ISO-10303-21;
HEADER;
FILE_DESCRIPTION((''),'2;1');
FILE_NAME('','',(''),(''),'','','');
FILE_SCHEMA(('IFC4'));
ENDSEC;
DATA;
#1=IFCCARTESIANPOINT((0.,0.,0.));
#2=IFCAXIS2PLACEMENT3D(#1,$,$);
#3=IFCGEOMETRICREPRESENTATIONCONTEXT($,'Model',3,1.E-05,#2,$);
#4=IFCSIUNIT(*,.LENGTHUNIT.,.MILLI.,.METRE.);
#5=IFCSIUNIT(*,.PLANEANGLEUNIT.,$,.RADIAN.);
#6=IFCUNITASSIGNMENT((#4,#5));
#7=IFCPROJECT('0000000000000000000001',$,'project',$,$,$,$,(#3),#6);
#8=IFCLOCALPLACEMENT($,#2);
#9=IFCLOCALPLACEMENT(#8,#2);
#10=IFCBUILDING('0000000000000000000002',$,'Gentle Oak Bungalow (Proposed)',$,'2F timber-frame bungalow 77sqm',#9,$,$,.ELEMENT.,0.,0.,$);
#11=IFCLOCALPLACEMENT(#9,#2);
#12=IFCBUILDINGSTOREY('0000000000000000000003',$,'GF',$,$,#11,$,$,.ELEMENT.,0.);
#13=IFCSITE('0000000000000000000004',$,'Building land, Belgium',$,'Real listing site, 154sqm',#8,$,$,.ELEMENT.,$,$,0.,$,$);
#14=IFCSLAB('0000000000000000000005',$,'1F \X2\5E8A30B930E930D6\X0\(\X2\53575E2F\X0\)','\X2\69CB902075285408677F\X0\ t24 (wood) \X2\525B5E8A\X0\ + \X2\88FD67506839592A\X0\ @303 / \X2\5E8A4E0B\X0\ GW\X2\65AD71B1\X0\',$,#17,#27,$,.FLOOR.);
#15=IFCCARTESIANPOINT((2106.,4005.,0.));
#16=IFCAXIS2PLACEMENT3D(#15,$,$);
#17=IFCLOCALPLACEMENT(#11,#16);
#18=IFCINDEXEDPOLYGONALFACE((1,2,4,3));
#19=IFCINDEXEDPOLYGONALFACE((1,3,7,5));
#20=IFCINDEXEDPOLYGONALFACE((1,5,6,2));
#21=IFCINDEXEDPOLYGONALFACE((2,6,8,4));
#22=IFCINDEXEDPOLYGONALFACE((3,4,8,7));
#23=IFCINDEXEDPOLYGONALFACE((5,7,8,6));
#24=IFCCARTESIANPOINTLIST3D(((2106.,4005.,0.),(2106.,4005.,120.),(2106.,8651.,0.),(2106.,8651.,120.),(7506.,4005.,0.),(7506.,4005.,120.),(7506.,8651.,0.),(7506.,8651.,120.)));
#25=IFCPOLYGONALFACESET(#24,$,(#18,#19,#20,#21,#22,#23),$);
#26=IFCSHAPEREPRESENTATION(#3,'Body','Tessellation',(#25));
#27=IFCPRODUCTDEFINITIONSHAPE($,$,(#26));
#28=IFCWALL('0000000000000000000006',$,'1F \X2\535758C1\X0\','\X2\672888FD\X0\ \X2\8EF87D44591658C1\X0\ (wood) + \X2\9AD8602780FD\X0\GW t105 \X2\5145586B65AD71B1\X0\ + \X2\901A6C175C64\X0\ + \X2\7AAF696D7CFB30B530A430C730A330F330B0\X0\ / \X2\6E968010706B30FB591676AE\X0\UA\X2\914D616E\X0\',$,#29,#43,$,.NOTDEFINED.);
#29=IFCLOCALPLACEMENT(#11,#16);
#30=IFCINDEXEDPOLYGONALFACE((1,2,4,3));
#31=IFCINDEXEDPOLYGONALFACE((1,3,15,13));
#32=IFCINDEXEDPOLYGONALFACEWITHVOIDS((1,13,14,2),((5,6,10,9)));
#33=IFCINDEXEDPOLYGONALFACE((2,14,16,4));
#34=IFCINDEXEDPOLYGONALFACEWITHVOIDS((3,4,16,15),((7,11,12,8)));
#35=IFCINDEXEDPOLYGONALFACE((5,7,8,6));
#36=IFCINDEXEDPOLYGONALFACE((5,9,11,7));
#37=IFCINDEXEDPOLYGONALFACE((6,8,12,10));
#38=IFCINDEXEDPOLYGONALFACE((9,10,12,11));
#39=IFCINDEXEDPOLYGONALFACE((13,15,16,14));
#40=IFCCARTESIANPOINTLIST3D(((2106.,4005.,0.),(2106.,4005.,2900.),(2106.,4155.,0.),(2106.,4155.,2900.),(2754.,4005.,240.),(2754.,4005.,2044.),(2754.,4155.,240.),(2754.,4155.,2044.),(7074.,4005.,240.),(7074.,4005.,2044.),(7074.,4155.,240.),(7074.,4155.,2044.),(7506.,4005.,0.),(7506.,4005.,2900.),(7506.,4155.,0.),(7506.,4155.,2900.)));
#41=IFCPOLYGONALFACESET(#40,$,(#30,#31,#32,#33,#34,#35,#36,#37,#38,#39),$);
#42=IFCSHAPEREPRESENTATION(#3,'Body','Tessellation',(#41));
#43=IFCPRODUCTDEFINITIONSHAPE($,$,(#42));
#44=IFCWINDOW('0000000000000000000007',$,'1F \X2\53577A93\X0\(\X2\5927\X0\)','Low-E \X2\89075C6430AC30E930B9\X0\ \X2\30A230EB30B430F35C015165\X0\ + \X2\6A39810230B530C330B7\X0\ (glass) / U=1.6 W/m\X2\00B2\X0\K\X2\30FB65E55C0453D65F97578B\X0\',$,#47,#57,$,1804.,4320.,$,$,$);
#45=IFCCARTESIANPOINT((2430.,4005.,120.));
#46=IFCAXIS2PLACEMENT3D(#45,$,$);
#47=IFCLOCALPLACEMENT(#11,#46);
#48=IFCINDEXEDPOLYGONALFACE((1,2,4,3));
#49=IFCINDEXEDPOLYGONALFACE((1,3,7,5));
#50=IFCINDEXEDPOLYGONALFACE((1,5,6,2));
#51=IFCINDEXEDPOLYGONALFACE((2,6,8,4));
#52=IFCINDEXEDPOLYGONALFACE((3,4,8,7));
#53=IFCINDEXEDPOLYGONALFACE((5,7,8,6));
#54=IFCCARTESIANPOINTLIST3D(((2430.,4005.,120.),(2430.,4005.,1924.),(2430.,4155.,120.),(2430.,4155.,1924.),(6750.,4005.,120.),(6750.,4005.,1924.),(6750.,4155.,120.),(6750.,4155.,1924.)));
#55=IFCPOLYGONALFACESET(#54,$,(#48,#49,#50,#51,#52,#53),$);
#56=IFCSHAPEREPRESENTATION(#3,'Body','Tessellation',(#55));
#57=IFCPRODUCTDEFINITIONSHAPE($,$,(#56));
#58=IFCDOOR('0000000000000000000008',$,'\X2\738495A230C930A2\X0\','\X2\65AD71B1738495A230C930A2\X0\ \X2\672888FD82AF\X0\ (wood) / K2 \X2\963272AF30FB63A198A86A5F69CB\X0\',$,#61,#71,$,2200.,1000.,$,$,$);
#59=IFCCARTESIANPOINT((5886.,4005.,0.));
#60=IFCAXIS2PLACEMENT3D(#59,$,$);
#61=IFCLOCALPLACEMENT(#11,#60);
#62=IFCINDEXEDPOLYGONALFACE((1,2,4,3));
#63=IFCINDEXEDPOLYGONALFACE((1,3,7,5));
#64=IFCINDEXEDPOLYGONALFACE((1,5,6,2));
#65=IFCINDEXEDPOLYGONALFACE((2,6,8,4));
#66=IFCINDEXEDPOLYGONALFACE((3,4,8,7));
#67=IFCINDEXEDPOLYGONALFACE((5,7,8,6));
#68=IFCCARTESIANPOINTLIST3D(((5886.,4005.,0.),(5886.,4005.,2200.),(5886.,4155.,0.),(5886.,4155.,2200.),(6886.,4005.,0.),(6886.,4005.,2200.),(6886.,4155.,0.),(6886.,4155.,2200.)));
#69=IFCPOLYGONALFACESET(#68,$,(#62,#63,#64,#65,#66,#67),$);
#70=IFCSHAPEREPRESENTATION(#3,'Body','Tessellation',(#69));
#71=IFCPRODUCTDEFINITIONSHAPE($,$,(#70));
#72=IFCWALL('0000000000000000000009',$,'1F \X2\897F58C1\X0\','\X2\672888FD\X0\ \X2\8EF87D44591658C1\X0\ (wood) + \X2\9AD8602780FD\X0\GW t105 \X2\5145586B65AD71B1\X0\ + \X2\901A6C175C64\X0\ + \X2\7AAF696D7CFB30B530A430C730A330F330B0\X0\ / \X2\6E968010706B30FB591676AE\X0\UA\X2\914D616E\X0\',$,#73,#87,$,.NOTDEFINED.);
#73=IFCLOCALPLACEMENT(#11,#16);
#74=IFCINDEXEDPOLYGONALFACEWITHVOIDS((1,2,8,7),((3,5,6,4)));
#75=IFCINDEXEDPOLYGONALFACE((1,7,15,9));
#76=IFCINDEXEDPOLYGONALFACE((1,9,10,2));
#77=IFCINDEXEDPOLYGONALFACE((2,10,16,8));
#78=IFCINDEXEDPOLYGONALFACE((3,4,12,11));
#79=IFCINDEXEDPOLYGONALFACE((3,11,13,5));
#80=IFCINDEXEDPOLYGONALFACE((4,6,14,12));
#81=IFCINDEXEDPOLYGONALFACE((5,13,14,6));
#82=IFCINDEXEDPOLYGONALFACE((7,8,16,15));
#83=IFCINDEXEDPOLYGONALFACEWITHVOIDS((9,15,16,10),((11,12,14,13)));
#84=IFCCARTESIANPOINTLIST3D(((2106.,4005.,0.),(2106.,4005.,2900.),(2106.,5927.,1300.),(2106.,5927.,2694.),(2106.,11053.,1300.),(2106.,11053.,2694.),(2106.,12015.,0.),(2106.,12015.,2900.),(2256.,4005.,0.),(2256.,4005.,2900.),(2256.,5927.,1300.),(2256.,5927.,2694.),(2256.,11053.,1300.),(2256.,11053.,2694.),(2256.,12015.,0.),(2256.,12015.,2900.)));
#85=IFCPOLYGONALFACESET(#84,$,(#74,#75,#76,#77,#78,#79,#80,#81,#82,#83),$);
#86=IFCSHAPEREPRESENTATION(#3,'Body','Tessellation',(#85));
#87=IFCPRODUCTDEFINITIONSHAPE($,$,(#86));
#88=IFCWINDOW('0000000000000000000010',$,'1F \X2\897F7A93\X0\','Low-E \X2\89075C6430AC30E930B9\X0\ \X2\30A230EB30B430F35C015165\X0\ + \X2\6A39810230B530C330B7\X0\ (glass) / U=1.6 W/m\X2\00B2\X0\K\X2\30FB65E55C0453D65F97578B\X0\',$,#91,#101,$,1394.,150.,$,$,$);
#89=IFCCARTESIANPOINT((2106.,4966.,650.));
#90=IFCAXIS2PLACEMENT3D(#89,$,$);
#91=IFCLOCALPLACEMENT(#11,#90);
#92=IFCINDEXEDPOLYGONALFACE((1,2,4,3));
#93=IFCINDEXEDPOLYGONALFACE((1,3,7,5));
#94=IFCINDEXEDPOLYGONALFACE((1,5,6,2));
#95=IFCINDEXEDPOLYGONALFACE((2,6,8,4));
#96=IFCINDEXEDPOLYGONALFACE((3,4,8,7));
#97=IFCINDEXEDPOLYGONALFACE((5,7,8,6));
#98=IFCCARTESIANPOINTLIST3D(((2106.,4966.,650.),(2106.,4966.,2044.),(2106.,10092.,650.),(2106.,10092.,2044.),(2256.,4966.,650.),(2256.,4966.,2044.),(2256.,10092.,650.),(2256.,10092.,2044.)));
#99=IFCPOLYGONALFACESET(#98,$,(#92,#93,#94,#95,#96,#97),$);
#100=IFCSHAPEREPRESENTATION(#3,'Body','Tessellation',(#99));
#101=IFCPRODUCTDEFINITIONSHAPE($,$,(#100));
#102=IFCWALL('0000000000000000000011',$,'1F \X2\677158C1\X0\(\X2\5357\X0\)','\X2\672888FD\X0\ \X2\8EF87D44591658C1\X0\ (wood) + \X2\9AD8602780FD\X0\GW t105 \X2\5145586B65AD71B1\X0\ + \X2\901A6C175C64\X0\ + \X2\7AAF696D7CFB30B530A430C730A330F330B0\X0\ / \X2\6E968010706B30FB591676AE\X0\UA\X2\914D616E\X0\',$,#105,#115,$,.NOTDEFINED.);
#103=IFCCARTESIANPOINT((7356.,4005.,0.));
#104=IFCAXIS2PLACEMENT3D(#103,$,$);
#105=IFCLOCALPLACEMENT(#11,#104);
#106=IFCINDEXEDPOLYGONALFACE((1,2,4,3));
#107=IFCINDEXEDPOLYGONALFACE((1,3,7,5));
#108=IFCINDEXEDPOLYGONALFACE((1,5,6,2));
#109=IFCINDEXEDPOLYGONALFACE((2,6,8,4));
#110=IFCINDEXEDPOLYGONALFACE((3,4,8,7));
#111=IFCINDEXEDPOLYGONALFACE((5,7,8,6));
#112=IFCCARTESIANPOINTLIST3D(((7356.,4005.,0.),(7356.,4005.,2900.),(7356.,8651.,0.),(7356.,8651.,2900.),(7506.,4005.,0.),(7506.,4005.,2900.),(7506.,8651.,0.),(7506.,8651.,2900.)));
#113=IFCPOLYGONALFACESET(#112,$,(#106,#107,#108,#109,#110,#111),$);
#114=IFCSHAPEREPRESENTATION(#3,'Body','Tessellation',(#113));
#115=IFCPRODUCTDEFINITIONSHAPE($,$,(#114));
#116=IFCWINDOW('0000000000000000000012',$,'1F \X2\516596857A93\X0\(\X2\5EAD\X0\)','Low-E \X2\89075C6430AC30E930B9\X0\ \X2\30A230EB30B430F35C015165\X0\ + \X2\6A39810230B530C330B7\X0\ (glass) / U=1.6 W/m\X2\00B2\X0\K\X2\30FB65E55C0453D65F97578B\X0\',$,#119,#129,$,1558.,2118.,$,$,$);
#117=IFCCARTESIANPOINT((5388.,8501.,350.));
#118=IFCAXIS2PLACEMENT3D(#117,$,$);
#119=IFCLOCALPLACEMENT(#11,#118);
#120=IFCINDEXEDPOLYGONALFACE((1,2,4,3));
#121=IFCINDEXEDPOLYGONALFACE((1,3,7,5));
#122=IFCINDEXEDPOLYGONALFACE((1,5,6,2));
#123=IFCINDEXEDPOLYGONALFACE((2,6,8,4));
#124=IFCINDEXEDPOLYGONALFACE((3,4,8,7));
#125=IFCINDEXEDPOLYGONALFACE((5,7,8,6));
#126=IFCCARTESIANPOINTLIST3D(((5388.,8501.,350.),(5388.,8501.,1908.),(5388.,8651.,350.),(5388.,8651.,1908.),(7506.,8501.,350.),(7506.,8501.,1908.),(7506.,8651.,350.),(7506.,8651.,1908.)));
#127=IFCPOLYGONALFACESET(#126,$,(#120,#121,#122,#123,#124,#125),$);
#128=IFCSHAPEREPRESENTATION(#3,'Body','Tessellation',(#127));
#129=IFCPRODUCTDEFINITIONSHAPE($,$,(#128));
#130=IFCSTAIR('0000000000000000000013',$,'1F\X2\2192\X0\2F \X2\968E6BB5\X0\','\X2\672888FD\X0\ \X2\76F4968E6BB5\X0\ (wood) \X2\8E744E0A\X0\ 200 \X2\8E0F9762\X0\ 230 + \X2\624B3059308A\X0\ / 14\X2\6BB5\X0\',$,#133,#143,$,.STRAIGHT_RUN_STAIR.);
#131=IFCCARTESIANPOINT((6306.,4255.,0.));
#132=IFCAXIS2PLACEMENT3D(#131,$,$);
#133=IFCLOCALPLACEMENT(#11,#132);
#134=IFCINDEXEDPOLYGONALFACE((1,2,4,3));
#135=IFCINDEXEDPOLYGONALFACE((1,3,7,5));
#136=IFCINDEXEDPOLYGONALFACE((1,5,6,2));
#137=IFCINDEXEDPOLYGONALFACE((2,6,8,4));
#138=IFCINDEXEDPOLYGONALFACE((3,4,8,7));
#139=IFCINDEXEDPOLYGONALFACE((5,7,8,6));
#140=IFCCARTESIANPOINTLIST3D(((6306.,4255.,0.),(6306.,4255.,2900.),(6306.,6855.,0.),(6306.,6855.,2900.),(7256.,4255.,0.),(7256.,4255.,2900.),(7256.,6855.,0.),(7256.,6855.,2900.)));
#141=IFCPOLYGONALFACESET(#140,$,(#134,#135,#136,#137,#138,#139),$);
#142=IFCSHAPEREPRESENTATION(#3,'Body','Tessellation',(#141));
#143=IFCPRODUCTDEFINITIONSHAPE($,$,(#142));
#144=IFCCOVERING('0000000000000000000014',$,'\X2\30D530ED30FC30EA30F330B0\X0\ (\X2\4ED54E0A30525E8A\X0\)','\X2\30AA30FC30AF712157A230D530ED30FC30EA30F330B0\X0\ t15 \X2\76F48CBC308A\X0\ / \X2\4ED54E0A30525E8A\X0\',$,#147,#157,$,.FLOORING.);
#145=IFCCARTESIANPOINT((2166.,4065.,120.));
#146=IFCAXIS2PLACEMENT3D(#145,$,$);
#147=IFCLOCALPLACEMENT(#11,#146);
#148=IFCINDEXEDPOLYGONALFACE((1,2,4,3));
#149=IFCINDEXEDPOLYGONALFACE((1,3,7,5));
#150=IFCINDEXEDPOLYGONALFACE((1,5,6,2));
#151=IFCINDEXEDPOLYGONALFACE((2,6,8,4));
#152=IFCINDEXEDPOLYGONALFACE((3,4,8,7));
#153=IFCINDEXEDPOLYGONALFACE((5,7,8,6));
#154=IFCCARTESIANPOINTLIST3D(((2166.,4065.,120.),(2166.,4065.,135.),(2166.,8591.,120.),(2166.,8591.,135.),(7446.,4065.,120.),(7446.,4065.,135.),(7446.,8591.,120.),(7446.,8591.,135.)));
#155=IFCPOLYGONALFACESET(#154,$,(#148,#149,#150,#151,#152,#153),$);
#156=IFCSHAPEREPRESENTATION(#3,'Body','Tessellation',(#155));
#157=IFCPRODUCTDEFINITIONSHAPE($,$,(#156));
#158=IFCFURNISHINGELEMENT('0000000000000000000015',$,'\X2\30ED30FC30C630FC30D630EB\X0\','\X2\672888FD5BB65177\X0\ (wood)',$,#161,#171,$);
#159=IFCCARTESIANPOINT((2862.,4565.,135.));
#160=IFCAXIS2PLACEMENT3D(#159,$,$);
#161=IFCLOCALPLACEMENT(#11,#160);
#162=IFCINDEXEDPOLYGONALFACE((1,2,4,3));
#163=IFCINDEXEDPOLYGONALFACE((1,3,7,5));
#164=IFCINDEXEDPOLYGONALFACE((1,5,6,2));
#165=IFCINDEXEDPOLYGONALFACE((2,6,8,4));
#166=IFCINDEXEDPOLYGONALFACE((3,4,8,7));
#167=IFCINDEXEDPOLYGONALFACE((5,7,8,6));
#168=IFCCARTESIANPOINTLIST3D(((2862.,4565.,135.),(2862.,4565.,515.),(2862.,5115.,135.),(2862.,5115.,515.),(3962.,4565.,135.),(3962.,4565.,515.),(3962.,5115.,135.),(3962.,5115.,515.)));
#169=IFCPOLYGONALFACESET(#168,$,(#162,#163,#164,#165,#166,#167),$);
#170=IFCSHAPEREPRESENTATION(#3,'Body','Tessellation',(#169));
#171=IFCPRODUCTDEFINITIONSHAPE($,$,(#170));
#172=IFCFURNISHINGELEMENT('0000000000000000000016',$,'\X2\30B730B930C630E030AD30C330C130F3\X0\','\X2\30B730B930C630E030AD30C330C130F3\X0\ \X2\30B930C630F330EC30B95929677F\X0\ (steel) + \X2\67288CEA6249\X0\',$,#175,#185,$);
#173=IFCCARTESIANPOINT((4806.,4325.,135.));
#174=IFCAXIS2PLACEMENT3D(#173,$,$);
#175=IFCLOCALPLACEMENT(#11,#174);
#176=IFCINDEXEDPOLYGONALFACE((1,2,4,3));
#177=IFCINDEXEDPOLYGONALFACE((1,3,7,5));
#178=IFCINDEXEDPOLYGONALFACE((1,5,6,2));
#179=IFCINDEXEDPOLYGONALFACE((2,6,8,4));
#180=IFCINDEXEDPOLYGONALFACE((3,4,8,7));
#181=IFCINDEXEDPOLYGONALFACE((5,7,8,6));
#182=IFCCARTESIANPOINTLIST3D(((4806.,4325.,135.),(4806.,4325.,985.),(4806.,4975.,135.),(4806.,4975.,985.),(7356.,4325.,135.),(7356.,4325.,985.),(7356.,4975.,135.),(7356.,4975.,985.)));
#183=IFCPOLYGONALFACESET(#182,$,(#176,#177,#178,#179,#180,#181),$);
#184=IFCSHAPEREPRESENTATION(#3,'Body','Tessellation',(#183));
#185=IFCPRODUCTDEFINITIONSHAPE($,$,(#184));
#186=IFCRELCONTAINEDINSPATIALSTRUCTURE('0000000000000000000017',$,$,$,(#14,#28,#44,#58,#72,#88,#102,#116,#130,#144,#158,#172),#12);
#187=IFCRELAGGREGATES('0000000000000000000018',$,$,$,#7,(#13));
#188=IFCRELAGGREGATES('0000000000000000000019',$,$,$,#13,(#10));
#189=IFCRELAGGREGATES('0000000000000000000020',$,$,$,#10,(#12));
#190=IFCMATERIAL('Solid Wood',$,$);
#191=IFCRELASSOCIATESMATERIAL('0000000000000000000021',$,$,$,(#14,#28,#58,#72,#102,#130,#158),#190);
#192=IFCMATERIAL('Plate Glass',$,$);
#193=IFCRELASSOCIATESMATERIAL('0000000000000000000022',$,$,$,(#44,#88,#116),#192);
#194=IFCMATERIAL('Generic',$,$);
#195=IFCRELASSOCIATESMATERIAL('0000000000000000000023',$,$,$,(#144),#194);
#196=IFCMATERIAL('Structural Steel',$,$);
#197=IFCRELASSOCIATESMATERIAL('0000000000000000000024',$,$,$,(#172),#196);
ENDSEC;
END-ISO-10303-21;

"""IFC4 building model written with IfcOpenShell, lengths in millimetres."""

from ifc_helpers import new_model, si_unit, frame, frame_2d, origin, place, context, project, spatial, rectangle, extrude, material, element, fill, save


model = new_model("IFC4")

# Units and contexts
model_context = context("Model", 3, precision=1e-05, world=origin())
ifc_project = project(units=[si_unit("LENGTHUNIT", "METRE", prefix="MILLI"), si_unit("PLANEANGLEUNIT", "RADIAN")], contexts=[model_context])

# Site, building, storey
site_placement = place(None, origin())
site = spatial("IfcSite", under=ifc_project, at=site_placement, Name="Building land, Belgium", ObjectType="Real listing site, 154sqm", CompositionType="ELEMENT", RefElevation=0.0)
building_placement = place(site_placement, origin())
building = spatial("IfcBuilding", under=site, at=building_placement, Name="Gentle Oak Bungalow (Proposed)", ObjectType="2F timber-frame bungalow 77sqm", CompositionType="ELEMENT", ElevationOfRefHeight=0.0, ElevationOfTerrain=0.0)
storey_placement = place(building_placement, origin())
storey = spatial("IfcBuildingStorey", under=building, at=storey_placement, Name="GF", CompositionType="ELEMENT", Elevation=0.0)

# Slab
ifc_material_1 = material(Name="Solid Wood")
slab_1_placement = place(storey_placement, frame((2106.0, 4005.0, 0.0)))
element("IfcSlab", 1, at=slab_1_placement, inside=storey, material=ifc_material_1, Name="1F 床スラブ(南帯)", Description="構造用合板 t24 (wood) 剛床 + 製材根太 @303 / 床下 GW断熱", PredefinedType="FLOOR", context=model_context, shape_type="SweptSolid", body=[
    extrude(rectangle(XDim=5400.0, YDim=4646.0, at=frame_2d((2700.0, 2323.0))), frame((2106.0, 4005.0, 0.0)), (0.0, 0.0, 1.0), 120.0),
])

# Wall, openings, window, door
wall_1_placement = place(storey_placement, frame((2106.0, 4005.0, 0.0)))
wall_1 = element("IfcWall", 2, at=wall_1_placement, inside=storey, material=ifc_material_1, Name="1F 南壁", Description="木製 軸組外壁 (wood) + 高性能GW t105 充填断熱 + 通気層 + 窯業系サイディング / 準耐火・外皮UA配慮", PredefinedType="NOTDEFINED", context=model_context, shape_type="SweptSolid", body=[
    extrude(rectangle(XDim=5400.0, YDim=150.0, at=frame_2d((2700.0, 75.0))), frame((2106.0, 4005.0, 0.0)), (0.0, 0.0, 1.0), 2900.0),
])
opening_1_placement = place(storey_placement, frame((2430.0, 4005.0, 120.0)))
opening_1 = element("IfcOpeningElement", 3, at=opening_1_placement, cuts=wall_1, PredefinedType="NOTDEFINED", context=model_context, shape_type="SweptSolid", body=[
    extrude(rectangle(XDim=4320.0, YDim=150.0, at=frame_2d((2160.0, 75.0))), frame((2430.0, 4005.0, 120.0)), (0.0, 0.0, 1.0), 1804.0),
])
opening_2_placement = place(storey_placement, frame((5886.0, 4005.0, 0.0)))
opening_2 = element("IfcOpeningElement", 4, at=opening_2_placement, cuts=wall_1, PredefinedType="NOTDEFINED", context=model_context, shape_type="SweptSolid", body=[
    extrude(rectangle(XDim=1000.0, YDim=150.0, at=frame_2d((500.0, 75.0))), frame((5886.0, 4005.0, 0.0)), (0.0, 0.0, 1.0), 2200.0),
])
ifc_material_2 = material(Name="Plate Glass")
window_1_placement = place(storey_placement, frame((2430.0, 4005.0, 120.0)))
window_1 = element("IfcWindow", 5, at=window_1_placement, inside=storey, material=ifc_material_2, Name="1F 南窓(大)", Description="Low-E 複層ガラス アルゴン封入 + 樹脂サッシ (glass) / U=1.6 W/m²K・日射取得型", OverallHeight=1804.0, OverallWidth=4320.0, context=model_context, shape_type="SweptSolid", body=[
    extrude(rectangle(XDim=4320.0, YDim=150.0, at=frame_2d((2160.0, 75.0))), frame((2430.0, 4005.0, 120.0)), (0.0, 0.0, 1.0), 1804.0),
])
fill(opening_1, window_1)
door_1_placement = place(storey_placement, frame((5886.0, 4005.0, 0.0)))
door_1 = element("IfcDoor", 6, at=door_1_placement, inside=storey, material=ifc_material_1, Name="玄関ドア", Description="断熱玄関ドア 木製芯 (wood) / K2 防犯・採風機構", OverallHeight=2200.0, OverallWidth=1000.0, context=model_context, shape_type="SweptSolid", body=[
    extrude(rectangle(XDim=1000.0, YDim=150.0, at=frame_2d((500.0, 75.0))), frame((5886.0, 4005.0, 0.0)), (0.0, 0.0, 1.0), 2200.0),
])
fill(opening_2, door_1)

# Walls, openings, windows
wall_2_placement = place(storey_placement, frame((2106.0, 4005.0, 0.0)))
wall_2 = element("IfcWall", 7, at=wall_2_placement, inside=storey, material=ifc_material_1, Name="1F 西壁", Description="木製 軸組外壁 (wood) + 高性能GW t105 充填断熱 + 通気層 + 窯業系サイディング / 準耐火・外皮UA配慮", PredefinedType="NOTDEFINED", context=model_context, shape_type="SweptSolid", body=[
    extrude(rectangle(XDim=150.0, YDim=8010.0, at=frame_2d((75.0, 4005.0))), frame((2106.0, 4005.0, 0.0)), (0.0, 0.0, 1.0), 2900.0),
])
opening_3_placement = place(storey_placement, frame((2106.0, 4966.0, 650.0)))
opening_3 = element("IfcOpeningElement", 8, at=opening_3_placement, cuts=wall_2, PredefinedType="NOTDEFINED", context=model_context, shape_type="SweptSolid", body=[
    extrude(rectangle(XDim=150.0, YDim=5126.0, at=frame_2d((75.0, 2563.0))), frame((2106.0, 4966.0, 650.0)), (0.0, 0.0, 1.0), 1394.0),
])
window_2_placement = place(storey_placement, frame((2106.0, 4966.0, 650.0)))
window_2 = element("IfcWindow", 9, at=window_2_placement, inside=storey, material=ifc_material_2, Name="1F 西窓", Description="Low-E 複層ガラス アルゴン封入 + 樹脂サッシ (glass) / U=1.6 W/m²K・日射取得型", OverallHeight=1394.0, OverallWidth=150.0, context=model_context, shape_type="SweptSolid", body=[
    extrude(rectangle(XDim=150.0, YDim=5126.0, at=frame_2d((75.0, 2563.0))), frame((2106.0, 4966.0, 650.0)), (0.0, 0.0, 1.0), 1394.0),
])
fill(opening_3, window_2)
wall_3_placement = place(storey_placement, frame((7356.0, 4005.0, 0.0)))
wall_3 = element("IfcWall", 10, at=wall_3_placement, inside=storey, material=ifc_material_1, Name="1F 東壁(南)", Description="木製 軸組外壁 (wood) + 高性能GW t105 充填断熱 + 通気層 + 窯業系サイディング / 準耐火・外皮UA配慮", PredefinedType="NOTDEFINED", context=model_context, shape_type="SweptSolid", body=[
    extrude(rectangle(XDim=150.0, YDim=4646.0, at=frame_2d((75.0, 2323.0))), frame((7356.0, 4005.0, 0.0)), (0.0, 0.0, 1.0), 2900.0),
])
opening_4_placement = place(storey_placement, frame((5388.0, 8501.0, 350.0)))
opening_4 = element("IfcOpeningElement", 11, at=opening_4_placement, cuts=wall_3, PredefinedType="NOTDEFINED", context=model_context, shape_type="SweptSolid", body=[
    extrude(rectangle(XDim=2118.0, YDim=150.0, at=frame_2d((1059.0, 75.0))), frame((5388.0, 8501.0, 350.0)), (0.0, 0.0, 1.0), 1558.0),
])
window_3_placement = place(storey_placement, frame((5388.0, 8501.0, 350.0)))
window_3 = element("IfcWindow", 12, at=window_3_placement, inside=storey, material=ifc_material_2, Name="1F 入隅窓(庭)", Description="Low-E 複層ガラス アルゴン封入 + 樹脂サッシ (glass) / U=1.6 W/m²K・日射取得型", OverallHeight=1558.0, OverallWidth=2118.0, context=model_context, shape_type="SweptSolid", body=[
    extrude(rectangle(XDim=2118.0, YDim=150.0, at=frame_2d((1059.0, 75.0))), frame((5388.0, 8501.0, 350.0)), (0.0, 0.0, 1.0), 1558.0),
])
fill(opening_4, window_3)

# Stair
stair_placement = place(storey_placement, frame((6306.0, 4255.0, 0.0)))
element("IfcStair", 13, at=stair_placement, inside=storey, material=ifc_material_1, Name="1F→2F 階段", Description="木製 直階段 (wood) 蹴上 200 踏面 230 + 手すり / 14段", PredefinedType="STRAIGHT_RUN_STAIR", context=model_context, shape_type="SweptSolid", body=[
    extrude(rectangle(XDim=950.0, YDim=2600.0, at=frame_2d((475.0, 1300.0))), frame((6306.0, 4255.0, 0.0)), (0.0, 0.0, 1.0), 2900.0),
])

# Covering
ifc_material_3 = material(Name="Generic")
covering_placement = place(storey_placement, frame((2166.0, 4065.0, 120.0)))
element("IfcCovering", 14, at=covering_placement, inside=storey, material=ifc_material_3, Name="フローリング (仕上げ床)", Description="オーク無垢フローリング t15 直貼り / 仕上げ床", PredefinedType="FLOORING", context=model_context, shape_type="SweptSolid", body=[
    extrude(rectangle(XDim=5280.0, YDim=4526.0, at=frame_2d((2640.0, 2263.0))), frame((2166.0, 4065.0, 120.0)), (0.0, 0.0, 1.0), 15.0),
])

# Furnishing elements
furnishing_1_placement = place(storey_placement, frame((2862.0, 4565.0, 135.0)))
element("IfcFurnishingElement", 15, at=furnishing_1_placement, inside=storey, material=ifc_material_1, Name="ローテーブル", Description="木製家具 (wood)", context=model_context, shape_type="SweptSolid", body=[
    extrude(rectangle(XDim=1100.0, YDim=550.0, at=frame_2d((550.0, 275.0))), frame((2862.0, 4565.0, 135.0)), (0.0, 0.0, 1.0), 380.0),
])
ifc_material_4 = material(Name="Structural Steel")
furnishing_2_placement = place(storey_placement, frame((4806.0, 4325.0, 135.0)))
element("IfcFurnishingElement", 16, at=furnishing_2_placement, inside=storey, material=ifc_material_4, Name="システムキッチン", Description="システムキッチン ステンレス天板 (steel) + 木質扉", context=model_context, shape_type="SweptSolid", body=[
    extrude(rectangle(XDim=2550.0, YDim=650.0, at=frame_2d((1275.0, 325.0))), frame((4806.0, 4325.0, 135.0)), (0.0, 0.0, 1.0), 850.0),
])

save(model, "model.ifc")
